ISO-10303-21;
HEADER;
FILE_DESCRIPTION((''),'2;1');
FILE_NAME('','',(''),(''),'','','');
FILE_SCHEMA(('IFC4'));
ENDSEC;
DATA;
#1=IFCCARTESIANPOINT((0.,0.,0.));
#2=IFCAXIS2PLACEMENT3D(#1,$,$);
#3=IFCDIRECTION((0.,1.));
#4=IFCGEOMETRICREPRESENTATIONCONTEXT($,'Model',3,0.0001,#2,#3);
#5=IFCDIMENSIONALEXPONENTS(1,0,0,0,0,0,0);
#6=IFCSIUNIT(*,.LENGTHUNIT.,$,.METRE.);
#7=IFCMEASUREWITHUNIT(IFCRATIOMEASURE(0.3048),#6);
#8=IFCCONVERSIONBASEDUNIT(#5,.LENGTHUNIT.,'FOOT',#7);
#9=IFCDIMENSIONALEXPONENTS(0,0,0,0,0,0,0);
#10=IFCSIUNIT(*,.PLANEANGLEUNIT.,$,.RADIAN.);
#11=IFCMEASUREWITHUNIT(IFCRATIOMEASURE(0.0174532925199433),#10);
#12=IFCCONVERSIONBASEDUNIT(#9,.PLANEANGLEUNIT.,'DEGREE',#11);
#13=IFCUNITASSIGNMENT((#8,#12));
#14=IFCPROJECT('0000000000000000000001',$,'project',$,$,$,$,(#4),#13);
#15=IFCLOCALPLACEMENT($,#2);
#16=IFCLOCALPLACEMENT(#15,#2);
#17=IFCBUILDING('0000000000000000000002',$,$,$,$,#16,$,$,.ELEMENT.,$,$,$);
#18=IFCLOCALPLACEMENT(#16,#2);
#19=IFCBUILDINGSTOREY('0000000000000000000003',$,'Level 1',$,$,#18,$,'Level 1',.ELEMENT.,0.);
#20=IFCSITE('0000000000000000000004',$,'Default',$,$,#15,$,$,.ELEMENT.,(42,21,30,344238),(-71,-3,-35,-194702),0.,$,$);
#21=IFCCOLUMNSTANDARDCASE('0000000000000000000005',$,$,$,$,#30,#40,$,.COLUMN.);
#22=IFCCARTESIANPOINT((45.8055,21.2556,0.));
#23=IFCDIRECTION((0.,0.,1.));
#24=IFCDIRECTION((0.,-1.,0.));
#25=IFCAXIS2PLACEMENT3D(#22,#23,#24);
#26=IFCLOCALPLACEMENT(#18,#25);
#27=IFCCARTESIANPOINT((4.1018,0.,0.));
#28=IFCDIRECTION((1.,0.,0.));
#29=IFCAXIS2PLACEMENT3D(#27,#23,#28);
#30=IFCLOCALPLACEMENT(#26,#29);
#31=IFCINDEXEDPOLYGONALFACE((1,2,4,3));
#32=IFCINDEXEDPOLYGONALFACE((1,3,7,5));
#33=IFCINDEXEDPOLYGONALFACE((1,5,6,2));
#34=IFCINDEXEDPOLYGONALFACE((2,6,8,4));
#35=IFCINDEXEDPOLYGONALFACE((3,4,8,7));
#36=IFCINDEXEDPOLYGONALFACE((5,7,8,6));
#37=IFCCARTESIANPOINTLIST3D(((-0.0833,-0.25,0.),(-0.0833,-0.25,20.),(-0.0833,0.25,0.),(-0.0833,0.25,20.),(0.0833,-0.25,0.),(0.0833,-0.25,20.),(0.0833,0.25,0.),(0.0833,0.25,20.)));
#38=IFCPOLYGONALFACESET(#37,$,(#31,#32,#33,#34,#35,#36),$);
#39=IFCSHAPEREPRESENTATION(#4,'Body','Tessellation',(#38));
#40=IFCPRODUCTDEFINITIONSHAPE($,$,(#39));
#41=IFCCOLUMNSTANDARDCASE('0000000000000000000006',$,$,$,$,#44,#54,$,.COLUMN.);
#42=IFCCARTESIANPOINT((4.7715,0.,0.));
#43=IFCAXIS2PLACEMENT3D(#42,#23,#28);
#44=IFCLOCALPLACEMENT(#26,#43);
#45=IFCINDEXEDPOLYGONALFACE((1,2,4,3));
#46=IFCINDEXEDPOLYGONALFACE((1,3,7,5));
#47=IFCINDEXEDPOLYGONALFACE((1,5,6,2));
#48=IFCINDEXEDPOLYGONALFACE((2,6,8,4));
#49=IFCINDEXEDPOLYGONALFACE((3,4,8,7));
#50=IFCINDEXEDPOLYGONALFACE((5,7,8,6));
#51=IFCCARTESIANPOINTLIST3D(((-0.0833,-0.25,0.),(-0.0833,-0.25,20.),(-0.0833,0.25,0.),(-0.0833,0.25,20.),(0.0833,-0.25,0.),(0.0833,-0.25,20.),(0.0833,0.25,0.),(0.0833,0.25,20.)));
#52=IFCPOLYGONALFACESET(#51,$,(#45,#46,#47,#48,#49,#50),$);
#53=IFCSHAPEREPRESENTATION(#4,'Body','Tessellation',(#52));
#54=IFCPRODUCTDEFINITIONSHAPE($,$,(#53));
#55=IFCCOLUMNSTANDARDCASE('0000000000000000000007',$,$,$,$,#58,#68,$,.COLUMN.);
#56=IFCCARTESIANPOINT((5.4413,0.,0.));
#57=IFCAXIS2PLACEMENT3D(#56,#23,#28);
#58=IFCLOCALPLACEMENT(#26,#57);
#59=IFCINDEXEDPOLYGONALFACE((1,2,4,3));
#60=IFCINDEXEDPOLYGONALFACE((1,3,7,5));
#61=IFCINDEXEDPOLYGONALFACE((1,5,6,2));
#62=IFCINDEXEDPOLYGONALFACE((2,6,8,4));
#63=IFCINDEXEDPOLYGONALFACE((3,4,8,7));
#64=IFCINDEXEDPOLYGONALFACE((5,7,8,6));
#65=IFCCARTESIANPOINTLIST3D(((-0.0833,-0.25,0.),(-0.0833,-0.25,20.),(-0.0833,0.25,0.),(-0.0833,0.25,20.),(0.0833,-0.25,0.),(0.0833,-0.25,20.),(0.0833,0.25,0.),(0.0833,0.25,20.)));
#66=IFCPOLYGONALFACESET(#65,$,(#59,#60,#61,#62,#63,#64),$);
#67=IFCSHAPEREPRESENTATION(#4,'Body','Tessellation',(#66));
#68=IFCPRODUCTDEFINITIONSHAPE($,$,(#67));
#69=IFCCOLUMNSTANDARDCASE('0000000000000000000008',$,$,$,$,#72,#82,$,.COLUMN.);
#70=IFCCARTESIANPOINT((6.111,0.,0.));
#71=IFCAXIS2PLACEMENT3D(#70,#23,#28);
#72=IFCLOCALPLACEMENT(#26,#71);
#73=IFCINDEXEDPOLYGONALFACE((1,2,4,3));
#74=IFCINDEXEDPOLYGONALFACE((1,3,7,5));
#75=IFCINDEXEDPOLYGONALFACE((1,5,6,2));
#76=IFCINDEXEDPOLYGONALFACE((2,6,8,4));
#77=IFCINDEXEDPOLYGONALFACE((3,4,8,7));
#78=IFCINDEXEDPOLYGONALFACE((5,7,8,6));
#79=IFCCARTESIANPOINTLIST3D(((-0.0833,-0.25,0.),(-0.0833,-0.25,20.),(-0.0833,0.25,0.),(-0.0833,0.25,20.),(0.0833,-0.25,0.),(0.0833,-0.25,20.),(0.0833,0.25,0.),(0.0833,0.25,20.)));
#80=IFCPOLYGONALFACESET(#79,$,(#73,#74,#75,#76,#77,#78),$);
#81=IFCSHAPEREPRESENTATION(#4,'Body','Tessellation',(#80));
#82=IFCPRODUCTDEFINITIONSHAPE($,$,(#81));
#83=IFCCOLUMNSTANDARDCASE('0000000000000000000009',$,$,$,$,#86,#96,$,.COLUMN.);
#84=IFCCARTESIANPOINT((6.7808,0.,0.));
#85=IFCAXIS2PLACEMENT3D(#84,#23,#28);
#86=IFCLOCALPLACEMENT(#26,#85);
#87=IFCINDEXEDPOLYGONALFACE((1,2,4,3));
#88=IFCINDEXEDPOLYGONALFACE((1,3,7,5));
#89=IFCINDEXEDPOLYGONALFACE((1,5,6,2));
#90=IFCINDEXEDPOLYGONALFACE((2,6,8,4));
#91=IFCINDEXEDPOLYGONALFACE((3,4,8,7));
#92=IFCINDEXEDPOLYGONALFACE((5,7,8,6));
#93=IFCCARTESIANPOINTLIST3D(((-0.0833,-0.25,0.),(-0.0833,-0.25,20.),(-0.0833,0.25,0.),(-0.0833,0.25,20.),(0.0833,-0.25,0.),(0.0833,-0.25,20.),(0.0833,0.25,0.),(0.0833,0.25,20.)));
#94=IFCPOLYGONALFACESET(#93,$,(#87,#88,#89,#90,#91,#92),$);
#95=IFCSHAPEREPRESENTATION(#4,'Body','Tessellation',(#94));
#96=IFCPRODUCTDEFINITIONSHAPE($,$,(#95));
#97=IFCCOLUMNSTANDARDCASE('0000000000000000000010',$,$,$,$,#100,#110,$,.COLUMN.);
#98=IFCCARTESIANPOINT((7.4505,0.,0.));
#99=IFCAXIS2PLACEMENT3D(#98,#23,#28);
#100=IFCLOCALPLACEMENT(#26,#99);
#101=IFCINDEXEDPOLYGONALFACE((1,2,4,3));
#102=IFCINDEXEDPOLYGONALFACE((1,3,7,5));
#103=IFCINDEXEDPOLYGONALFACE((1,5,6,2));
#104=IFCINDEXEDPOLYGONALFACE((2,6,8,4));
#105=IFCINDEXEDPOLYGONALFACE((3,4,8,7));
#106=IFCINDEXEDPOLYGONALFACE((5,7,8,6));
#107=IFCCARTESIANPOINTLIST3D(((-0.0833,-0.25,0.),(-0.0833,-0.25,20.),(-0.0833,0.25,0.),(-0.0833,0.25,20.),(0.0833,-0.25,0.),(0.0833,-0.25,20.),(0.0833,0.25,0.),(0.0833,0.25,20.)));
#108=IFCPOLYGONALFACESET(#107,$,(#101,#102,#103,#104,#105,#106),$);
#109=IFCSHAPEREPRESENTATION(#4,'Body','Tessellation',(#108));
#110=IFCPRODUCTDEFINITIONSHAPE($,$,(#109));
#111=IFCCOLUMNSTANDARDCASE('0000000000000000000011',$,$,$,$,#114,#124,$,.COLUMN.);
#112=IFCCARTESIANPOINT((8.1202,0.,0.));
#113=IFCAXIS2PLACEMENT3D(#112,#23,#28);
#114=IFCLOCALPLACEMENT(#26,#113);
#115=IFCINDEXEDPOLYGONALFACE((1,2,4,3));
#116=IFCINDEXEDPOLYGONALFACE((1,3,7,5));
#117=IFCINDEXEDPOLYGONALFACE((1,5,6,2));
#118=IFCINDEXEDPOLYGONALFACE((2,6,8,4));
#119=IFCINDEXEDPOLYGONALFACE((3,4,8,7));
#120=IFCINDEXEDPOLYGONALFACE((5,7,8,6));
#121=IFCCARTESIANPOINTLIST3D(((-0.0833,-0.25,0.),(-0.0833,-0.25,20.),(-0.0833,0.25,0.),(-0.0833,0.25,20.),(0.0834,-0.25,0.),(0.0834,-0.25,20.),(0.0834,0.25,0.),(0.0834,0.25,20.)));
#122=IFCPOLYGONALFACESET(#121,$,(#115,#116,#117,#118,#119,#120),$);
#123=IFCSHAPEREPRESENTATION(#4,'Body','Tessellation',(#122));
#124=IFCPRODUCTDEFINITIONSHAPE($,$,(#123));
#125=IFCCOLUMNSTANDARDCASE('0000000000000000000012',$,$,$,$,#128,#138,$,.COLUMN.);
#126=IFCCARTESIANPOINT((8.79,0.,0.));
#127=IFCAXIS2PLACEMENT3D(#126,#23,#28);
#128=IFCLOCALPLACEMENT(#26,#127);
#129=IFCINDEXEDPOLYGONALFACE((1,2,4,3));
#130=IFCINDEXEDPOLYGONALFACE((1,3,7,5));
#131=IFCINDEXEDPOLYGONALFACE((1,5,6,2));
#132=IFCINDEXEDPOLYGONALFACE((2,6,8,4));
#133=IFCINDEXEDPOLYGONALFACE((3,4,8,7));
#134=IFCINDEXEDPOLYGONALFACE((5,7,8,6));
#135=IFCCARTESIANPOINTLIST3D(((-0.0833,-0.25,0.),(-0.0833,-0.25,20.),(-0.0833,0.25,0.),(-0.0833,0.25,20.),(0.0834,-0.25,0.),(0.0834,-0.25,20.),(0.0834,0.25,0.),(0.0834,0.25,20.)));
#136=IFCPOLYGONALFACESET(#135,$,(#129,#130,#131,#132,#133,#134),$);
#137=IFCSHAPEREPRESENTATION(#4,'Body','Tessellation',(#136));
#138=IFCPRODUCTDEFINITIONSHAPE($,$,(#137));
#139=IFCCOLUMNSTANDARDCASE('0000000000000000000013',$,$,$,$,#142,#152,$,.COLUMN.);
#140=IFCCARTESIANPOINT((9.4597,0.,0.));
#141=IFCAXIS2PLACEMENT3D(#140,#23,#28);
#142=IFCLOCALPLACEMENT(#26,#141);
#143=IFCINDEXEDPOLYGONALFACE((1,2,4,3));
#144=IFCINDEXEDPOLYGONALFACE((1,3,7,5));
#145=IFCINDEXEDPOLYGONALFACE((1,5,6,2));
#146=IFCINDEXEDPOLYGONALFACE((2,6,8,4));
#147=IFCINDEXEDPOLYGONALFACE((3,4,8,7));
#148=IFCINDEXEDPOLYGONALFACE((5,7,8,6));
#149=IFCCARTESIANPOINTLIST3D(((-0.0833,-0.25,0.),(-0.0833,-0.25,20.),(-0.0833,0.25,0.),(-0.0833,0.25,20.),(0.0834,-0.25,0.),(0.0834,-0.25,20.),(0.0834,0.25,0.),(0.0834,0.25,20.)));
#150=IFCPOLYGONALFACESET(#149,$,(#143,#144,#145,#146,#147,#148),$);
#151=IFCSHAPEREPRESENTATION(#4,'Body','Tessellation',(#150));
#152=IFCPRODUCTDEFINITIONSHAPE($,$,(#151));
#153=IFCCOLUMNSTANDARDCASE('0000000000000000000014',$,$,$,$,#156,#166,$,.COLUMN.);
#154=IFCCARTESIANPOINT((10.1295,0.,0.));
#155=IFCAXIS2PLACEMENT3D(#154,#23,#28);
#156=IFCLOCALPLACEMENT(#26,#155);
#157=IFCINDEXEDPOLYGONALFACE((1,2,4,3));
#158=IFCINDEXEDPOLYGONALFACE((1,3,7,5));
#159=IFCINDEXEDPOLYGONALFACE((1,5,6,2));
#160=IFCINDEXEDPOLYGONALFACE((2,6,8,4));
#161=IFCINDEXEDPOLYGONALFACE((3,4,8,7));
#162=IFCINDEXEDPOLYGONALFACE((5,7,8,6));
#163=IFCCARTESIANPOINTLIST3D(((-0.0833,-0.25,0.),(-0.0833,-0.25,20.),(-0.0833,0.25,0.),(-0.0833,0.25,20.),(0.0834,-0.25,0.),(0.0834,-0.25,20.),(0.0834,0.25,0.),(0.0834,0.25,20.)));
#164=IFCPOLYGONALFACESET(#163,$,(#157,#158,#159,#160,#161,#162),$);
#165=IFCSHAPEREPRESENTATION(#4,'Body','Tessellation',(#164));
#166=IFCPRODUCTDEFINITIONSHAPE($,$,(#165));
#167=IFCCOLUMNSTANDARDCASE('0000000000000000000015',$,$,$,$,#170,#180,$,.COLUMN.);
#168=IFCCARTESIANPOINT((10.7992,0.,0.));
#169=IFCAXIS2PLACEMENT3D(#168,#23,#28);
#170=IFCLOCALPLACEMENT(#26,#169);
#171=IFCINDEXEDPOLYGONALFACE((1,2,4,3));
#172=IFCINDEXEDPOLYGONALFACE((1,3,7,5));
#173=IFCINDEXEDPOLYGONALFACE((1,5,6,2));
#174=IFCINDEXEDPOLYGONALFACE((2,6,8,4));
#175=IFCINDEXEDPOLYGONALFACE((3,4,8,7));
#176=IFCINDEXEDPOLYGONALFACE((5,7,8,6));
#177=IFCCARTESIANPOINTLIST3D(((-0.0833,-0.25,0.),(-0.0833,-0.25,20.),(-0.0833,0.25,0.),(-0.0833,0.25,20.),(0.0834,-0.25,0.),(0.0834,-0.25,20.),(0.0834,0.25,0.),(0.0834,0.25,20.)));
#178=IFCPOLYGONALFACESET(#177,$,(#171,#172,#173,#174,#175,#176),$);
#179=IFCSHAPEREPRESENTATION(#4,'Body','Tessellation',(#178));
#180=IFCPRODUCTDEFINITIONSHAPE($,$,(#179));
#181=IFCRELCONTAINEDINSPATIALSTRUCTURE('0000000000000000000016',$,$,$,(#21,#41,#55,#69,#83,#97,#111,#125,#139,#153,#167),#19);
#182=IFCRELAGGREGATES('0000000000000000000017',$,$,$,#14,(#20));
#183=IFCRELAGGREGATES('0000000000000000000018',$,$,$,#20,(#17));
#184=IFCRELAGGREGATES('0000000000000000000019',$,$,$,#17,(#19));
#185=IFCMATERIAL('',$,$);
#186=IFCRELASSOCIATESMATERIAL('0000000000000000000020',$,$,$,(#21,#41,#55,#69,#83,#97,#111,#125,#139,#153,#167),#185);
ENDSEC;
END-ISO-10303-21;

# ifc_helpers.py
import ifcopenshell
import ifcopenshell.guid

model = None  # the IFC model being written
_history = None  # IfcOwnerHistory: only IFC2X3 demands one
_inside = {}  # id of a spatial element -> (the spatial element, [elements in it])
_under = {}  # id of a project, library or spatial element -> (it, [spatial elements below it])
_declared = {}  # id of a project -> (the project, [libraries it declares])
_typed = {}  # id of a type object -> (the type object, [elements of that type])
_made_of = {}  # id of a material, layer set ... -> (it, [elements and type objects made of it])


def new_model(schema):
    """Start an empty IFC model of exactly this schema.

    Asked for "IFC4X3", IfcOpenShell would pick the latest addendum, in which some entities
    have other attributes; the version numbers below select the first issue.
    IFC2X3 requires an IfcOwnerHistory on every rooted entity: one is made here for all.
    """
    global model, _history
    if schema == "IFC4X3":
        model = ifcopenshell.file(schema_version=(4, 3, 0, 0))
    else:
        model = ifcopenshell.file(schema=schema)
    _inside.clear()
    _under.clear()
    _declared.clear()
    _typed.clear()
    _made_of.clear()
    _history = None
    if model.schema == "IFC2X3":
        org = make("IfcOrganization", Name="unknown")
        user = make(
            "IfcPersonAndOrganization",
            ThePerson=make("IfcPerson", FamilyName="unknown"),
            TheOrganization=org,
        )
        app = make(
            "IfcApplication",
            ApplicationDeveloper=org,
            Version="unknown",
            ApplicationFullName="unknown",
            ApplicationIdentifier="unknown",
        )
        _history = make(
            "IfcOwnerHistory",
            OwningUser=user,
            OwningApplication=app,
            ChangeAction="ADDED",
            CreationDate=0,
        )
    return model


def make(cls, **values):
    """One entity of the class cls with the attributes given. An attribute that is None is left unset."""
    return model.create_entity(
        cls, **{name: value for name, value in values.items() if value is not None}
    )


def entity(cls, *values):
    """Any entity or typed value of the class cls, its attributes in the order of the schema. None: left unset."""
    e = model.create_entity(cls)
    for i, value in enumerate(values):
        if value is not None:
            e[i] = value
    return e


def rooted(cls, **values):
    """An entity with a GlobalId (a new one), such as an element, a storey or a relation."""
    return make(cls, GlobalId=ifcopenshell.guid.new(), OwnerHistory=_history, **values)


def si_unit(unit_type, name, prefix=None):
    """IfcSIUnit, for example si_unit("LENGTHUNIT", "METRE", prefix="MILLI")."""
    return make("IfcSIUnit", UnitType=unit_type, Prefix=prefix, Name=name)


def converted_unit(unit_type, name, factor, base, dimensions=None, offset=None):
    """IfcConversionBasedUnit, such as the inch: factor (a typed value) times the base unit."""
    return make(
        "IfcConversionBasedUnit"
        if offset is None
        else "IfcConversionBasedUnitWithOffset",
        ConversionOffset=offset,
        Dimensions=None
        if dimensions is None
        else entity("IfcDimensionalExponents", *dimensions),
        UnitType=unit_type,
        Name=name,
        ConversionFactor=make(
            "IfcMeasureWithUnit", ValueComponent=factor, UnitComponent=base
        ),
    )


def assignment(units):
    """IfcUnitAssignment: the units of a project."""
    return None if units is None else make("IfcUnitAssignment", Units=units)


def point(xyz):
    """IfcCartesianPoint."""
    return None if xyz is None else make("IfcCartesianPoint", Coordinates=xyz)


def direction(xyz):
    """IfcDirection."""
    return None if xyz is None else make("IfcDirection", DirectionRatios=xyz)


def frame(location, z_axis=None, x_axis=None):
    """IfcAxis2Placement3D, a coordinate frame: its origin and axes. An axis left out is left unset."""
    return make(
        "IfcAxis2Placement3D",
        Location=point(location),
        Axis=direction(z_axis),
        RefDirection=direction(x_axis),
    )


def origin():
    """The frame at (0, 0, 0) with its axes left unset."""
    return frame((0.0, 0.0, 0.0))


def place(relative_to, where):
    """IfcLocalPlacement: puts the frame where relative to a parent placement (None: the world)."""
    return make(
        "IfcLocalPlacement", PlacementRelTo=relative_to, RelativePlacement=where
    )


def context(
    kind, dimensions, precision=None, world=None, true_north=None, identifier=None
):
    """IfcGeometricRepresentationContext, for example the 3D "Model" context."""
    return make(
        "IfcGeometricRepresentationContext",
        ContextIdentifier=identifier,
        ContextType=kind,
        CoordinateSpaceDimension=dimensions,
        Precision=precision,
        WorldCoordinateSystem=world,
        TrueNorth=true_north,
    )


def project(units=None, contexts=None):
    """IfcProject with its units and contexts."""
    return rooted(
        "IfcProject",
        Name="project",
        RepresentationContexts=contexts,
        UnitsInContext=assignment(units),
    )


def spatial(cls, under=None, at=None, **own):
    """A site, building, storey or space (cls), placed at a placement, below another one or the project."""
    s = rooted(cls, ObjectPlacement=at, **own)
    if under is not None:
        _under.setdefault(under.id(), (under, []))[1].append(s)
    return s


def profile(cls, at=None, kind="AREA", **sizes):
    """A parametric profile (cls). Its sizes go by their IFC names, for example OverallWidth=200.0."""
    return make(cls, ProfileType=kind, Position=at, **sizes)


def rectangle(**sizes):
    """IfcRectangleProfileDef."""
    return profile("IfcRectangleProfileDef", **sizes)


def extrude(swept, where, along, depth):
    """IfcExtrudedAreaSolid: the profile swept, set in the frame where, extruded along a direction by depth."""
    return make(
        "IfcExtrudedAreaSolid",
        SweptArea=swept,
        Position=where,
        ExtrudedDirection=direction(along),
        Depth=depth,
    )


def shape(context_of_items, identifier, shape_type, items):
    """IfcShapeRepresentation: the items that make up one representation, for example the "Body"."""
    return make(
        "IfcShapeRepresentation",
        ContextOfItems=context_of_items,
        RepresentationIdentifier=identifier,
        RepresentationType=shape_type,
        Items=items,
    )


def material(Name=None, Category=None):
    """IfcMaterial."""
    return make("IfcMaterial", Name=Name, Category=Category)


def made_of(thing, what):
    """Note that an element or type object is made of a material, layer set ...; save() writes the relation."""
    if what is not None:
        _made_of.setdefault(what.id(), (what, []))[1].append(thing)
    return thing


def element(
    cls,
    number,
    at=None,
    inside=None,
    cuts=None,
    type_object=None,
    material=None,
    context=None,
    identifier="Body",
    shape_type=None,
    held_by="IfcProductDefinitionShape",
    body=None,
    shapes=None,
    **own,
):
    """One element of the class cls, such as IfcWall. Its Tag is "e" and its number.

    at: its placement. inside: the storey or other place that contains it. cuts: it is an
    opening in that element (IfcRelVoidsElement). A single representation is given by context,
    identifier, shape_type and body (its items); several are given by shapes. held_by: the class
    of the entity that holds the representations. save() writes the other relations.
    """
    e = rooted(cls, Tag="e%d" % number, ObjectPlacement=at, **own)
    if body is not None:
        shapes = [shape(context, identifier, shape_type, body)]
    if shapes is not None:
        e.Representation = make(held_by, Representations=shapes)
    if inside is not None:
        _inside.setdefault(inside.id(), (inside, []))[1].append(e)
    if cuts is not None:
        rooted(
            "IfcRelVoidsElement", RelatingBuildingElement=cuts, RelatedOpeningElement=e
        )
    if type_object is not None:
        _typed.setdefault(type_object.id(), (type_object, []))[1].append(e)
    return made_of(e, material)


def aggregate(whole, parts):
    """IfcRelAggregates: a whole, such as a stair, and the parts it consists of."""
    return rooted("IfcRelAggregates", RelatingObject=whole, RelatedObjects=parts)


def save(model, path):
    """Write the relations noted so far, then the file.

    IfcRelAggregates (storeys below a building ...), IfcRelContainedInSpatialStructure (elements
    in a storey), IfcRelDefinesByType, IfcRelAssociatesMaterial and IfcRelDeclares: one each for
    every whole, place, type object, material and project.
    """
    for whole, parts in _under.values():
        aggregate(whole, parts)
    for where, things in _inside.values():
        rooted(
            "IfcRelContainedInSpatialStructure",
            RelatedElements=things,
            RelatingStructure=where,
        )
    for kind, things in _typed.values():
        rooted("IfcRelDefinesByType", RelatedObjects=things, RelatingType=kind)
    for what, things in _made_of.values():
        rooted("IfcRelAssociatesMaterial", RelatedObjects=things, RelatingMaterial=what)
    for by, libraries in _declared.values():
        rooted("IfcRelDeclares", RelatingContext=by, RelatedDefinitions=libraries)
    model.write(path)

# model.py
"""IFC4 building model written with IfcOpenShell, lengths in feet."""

from ifc_helpers import new_model, entity, si_unit, converted_unit, direction, frame, origin, place, context, project, spatial, rectangle, extrude, material, element, save


model = new_model("IFC4")

# Units and contexts
model_context = context("Model", 3, precision=0.0001, world=origin(), true_north=direction((0.0, 1.0)))
ifc_project = project(units=[converted_unit("LENGTHUNIT", "FOOT", entity("IfcRatioMeasure", 0.3048), si_unit("LENGTHUNIT", "METRE"), dimensions=[1, 0, 0, 0, 0, 0, 0]), converted_unit("PLANEANGLEUNIT", "DEGREE", entity("IfcRatioMeasure", 0.0174532925199433), si_unit("PLANEANGLEUNIT", "RADIAN"), dimensions=[0, 0, 0, 0, 0, 0, 0])], contexts=[model_context])

# Site, building, storey
site_placement = place(None, origin())
site = spatial("IfcSite", under=ifc_project, at=site_placement, Name="Default", CompositionType="ELEMENT", RefLatitude=(42, 21, 30, 344238), RefLongitude=(-71, -3, -35, -194702), RefElevation=0.0)
building_placement = place(site_placement, origin())
building = spatial("IfcBuilding", under=site, at=building_placement, CompositionType="ELEMENT")
storey_placement = place(building_placement, origin())
storey = spatial("IfcBuildingStorey", under=building, at=storey_placement, Name="Level 1", LongName="Level 1", CompositionType="ELEMENT", Elevation=0.0)

# Columns
ifc_material_1 = material(Name="")
wall_1_placement = place(storey_placement, frame((45.8055, 21.2556, 0.0), z_axis=(0.0, 0.0, 1.0), x_axis=(0.0, -1.0, 0.0)))
for number, where, z_axis, x_axis in (
    (1, (4.1018, 0.0, 0.0), (0.0, 0.0, 1.0), (1.0, 0.0, 0.0)),
    (2, (4.7715, 0.0, 0.0), (0.0, 0.0, 1.0), (1.0, 0.0, 0.0)),
    (3, (5.4413, 0.0, 0.0), (0.0, 0.0, 1.0), (1.0, 0.0, 0.0)),
    (4, (6.111, 0.0, 0.0), (0.0, 0.0, 1.0), (1.0, 0.0, 0.0)),
    (5, (6.7808, 0.0, 0.0), (0.0, 0.0, 1.0), (1.0, 0.0, 0.0)),
    (6, (7.4505, 0.0, 0.0), (0.0, 0.0, 1.0), (1.0, 0.0, 0.0)),
    (7, (8.1202, 0.0, 0.0), (0.0, 0.0, 1.0), (1.0, 0.0, 0.0)),
    (8, (8.79, 0.0, 0.0), (0.0, 0.0, 1.0), (1.0, 0.0, 0.0)),
    (9, (9.4597, 0.0, 0.0), (0.0, 0.0, 1.0), (1.0, 0.0, 0.0)),
    (10, (10.1295, 0.0, 0.0), (0.0, 0.0, 1.0), (1.0, 0.0, 0.0)),
    (11, (10.7992, 0.0, 0.0), (0.0, 0.0, 1.0), (1.0, 0.0, 0.0)),
):
    element("IfcColumnStandardCase", number, at=place(wall_1_placement, frame(where, z_axis=z_axis, x_axis=x_axis)), inside=storey, material=ifc_material_1, PredefinedType="COLUMN", context=model_context, shape_type="SweptSolid", body=[
        extrude(rectangle(XDim=0.1667, YDim=0.5), origin(), (0.0, 0.0, 1.0), 20.0),
    ])

save(model, "model.ifc")
